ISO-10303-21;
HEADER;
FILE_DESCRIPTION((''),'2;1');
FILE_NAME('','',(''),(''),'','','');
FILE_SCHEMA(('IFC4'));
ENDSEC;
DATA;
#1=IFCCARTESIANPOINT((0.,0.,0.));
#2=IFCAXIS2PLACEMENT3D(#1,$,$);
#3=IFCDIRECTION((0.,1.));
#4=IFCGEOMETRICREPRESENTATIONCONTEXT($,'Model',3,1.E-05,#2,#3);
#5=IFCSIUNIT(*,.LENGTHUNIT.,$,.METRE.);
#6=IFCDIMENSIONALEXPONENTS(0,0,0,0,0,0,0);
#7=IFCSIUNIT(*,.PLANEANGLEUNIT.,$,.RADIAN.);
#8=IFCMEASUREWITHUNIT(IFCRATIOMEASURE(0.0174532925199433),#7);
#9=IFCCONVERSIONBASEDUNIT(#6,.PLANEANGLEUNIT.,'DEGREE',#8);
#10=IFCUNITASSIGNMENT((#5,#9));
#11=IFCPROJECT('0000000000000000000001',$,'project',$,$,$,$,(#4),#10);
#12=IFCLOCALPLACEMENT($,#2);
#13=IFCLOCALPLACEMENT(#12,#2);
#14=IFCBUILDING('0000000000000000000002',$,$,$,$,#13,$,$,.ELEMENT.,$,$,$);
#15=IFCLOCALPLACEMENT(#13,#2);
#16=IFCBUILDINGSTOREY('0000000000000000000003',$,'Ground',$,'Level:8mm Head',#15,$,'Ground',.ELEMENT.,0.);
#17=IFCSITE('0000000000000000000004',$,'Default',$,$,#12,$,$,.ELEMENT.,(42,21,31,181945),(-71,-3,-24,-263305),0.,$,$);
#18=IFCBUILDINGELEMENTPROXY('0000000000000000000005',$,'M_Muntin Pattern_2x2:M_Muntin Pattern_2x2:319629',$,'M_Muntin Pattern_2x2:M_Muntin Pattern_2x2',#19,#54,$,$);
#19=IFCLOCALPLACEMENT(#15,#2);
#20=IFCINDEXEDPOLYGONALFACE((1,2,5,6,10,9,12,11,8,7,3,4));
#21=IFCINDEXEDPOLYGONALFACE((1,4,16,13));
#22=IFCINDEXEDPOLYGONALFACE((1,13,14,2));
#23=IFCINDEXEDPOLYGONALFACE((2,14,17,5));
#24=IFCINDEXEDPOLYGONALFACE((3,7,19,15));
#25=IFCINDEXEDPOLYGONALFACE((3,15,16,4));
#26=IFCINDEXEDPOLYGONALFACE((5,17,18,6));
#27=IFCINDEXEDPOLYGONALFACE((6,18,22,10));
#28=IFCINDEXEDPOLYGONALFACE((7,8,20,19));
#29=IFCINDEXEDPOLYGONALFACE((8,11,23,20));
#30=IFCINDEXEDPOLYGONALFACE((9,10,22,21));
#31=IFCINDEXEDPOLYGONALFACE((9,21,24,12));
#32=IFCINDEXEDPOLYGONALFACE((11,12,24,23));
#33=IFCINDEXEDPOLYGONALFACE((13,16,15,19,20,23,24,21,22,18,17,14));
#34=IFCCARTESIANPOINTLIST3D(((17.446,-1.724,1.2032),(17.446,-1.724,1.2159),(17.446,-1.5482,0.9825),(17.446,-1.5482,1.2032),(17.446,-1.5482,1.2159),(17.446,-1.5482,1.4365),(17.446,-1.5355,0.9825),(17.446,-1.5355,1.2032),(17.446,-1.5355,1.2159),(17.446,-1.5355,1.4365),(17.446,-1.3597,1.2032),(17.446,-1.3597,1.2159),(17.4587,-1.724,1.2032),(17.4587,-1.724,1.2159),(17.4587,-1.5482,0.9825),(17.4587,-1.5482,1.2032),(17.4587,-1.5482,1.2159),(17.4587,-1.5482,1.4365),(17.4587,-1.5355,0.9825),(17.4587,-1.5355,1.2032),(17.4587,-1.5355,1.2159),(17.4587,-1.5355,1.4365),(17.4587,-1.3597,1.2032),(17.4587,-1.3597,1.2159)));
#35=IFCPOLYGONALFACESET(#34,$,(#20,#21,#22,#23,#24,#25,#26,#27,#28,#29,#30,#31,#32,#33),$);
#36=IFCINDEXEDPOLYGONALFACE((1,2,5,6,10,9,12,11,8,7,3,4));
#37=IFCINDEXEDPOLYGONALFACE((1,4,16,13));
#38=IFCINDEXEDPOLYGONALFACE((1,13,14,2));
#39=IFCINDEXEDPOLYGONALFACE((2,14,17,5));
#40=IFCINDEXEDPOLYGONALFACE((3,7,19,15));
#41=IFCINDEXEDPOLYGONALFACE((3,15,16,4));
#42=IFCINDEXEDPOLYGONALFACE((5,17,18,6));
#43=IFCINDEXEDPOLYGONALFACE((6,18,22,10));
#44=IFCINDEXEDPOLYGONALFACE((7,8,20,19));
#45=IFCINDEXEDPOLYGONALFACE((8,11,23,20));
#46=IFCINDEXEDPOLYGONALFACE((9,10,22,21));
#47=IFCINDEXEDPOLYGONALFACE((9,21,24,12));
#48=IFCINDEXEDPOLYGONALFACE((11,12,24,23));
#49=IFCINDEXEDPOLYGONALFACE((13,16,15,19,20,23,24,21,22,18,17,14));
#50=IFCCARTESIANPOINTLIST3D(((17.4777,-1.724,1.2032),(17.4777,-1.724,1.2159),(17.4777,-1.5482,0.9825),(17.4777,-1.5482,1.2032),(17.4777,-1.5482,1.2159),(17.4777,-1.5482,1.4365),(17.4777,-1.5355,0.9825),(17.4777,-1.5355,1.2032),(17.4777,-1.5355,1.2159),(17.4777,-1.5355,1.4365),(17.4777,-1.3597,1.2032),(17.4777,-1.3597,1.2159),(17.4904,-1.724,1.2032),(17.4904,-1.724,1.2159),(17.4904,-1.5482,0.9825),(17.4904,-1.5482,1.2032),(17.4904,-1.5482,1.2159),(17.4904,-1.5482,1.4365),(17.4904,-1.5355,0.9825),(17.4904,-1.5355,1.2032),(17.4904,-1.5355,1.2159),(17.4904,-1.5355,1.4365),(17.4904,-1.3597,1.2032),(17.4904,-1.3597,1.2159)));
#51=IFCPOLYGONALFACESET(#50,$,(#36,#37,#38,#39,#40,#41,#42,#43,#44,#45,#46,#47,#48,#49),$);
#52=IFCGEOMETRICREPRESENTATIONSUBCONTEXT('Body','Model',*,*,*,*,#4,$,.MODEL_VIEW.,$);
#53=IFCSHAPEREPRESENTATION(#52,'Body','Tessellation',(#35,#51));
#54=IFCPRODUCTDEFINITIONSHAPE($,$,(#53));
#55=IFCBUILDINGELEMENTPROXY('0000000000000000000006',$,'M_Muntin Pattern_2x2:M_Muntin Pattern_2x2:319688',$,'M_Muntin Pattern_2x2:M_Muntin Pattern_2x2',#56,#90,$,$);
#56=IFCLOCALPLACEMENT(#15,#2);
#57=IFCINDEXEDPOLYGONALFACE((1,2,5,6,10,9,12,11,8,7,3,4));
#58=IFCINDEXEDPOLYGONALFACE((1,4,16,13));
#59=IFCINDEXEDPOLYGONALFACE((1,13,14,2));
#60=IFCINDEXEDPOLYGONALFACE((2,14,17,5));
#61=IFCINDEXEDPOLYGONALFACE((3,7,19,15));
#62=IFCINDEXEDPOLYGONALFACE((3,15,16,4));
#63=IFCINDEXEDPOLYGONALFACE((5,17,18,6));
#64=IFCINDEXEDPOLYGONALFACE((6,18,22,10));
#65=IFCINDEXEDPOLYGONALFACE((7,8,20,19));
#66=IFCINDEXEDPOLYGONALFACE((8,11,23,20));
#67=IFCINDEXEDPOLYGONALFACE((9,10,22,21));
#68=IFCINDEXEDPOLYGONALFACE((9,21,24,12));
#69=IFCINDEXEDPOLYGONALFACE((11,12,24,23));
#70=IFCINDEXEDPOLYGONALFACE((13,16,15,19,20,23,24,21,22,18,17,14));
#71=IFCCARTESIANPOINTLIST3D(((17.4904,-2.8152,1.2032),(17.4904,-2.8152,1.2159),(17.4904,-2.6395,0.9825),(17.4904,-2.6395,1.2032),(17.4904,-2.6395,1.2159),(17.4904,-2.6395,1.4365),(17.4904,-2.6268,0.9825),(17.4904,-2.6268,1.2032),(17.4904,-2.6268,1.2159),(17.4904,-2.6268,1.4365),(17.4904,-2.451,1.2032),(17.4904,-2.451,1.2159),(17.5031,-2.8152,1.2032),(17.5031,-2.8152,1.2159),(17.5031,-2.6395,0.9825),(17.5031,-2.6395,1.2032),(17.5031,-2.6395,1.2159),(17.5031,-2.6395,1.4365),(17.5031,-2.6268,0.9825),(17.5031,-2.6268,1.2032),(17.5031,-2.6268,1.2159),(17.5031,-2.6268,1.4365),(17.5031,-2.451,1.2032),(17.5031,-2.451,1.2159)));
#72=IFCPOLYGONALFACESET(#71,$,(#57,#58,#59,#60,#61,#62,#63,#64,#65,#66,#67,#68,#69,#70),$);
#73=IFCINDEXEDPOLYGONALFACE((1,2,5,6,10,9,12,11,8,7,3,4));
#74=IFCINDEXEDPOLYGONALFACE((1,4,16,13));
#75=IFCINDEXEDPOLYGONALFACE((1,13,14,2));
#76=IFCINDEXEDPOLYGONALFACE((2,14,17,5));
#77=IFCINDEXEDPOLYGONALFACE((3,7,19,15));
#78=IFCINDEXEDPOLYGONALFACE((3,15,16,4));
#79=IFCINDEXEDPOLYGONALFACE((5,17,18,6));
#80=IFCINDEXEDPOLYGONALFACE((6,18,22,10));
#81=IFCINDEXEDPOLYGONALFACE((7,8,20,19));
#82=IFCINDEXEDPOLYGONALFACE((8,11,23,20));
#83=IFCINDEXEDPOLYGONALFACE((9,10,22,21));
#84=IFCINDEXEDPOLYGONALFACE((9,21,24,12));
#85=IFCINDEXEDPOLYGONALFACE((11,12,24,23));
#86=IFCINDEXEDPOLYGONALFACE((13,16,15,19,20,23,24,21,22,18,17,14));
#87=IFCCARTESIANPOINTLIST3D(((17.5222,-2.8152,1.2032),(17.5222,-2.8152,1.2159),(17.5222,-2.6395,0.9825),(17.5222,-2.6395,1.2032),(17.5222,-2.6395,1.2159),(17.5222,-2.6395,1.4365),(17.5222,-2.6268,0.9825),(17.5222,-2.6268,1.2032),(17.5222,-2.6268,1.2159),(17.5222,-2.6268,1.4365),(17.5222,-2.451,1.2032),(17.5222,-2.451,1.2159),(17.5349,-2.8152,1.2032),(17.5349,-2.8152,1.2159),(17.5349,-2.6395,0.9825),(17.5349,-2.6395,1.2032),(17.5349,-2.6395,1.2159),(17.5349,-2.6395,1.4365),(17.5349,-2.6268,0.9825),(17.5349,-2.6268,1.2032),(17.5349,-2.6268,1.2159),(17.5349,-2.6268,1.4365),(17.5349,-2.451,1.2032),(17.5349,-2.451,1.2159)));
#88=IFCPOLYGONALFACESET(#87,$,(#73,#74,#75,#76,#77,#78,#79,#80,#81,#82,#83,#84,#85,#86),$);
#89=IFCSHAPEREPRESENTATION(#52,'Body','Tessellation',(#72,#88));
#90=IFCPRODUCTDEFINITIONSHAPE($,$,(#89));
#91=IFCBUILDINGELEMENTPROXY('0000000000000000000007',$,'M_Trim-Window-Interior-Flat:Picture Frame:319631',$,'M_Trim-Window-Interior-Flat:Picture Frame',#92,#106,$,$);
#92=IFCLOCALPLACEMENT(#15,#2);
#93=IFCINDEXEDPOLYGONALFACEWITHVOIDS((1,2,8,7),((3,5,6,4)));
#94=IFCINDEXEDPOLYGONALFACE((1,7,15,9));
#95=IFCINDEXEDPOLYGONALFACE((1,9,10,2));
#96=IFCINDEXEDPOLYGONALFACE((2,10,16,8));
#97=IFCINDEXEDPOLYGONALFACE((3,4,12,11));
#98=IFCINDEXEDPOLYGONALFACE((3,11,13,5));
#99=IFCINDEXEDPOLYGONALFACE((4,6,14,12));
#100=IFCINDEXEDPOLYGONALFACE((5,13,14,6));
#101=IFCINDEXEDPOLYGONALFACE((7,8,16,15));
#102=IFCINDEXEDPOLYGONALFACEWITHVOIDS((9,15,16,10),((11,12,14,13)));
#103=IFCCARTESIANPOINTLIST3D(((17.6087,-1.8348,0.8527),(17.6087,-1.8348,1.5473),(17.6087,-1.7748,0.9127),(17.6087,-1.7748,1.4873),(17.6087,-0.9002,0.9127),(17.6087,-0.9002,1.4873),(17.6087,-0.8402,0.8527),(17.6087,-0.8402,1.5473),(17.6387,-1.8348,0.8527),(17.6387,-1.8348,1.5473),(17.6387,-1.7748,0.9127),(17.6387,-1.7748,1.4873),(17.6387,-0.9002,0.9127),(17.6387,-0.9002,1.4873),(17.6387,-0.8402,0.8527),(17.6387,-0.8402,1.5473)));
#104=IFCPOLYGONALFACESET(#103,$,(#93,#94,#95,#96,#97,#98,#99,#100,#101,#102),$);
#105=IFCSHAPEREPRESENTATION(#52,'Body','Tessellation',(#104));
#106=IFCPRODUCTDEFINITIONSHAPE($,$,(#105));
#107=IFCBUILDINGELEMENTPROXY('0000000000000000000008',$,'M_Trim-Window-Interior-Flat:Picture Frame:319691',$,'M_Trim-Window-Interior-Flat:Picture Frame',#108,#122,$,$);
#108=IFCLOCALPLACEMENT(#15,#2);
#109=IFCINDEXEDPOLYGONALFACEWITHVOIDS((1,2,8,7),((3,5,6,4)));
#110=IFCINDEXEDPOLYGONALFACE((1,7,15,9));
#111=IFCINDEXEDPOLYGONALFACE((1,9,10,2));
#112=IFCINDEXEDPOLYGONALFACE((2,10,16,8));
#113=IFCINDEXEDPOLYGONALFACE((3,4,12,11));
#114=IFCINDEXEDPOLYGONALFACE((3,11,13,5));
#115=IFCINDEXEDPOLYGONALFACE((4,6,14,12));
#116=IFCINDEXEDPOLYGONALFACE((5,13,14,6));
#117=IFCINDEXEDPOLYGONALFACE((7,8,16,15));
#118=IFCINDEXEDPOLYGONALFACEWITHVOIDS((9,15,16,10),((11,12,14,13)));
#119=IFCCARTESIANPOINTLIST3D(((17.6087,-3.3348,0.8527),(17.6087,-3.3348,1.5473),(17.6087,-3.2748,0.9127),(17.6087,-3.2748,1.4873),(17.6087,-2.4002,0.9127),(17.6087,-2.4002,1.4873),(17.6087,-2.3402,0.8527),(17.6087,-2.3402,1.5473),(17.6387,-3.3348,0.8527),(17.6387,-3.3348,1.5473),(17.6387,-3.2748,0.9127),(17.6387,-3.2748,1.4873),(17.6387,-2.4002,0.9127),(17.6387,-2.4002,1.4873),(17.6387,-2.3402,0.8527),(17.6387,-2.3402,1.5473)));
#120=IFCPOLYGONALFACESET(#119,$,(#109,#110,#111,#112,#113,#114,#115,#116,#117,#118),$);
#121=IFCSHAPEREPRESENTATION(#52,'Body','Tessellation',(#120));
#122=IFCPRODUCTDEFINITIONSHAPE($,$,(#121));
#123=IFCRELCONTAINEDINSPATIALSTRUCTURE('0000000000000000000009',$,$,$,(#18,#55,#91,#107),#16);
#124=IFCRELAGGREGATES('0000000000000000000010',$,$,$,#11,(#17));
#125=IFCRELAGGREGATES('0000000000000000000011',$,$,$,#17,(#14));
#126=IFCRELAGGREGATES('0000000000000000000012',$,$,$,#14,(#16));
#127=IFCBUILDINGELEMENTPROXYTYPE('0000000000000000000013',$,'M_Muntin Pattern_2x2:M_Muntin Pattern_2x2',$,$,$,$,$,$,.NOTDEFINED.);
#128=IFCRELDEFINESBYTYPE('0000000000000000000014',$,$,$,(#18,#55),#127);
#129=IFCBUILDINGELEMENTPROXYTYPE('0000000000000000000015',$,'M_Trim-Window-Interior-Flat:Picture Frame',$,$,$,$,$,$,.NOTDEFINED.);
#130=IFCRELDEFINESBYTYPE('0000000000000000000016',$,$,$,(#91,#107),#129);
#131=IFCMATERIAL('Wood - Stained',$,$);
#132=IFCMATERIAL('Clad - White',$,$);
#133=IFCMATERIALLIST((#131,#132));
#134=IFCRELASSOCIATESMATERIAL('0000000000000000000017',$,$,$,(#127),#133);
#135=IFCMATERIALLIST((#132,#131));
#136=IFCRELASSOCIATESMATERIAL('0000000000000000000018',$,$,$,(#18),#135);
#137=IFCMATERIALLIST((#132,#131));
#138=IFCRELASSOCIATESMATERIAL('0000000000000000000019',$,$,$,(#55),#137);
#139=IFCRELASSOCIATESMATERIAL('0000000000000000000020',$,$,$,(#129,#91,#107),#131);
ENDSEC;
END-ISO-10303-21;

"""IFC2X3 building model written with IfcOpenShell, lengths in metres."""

from ifc_helpers import new_model, entity, si_unit, converted_unit, direction, frame, origin, place, context, subcontext, project, spatial, polyline, outline, extrude, source, transform, mapped, material, material_list, type_object, type_shapes, element, save


model = new_model("IFC2X3")

# Units and contexts
model_context = context("Model", 3, precision=1e-05, world=origin(), true_north=direction((0.0, 1.0)))
body_context = subcontext(model_context, "Body", "Model", "MODEL_VIEW")
ifc_project = project(units=[si_unit("LENGTHUNIT", "METRE"), converted_unit("PLANEANGLEUNIT", "DEGREE", entity("IfcRatioMeasure", 0.0174532925199433), si_unit("PLANEANGLEUNIT", "RADIAN"), dimensions=[0, 0, 0, 0, 0, 0, 0])], contexts=[model_context])

# Site, building, storey
site_placement = place(None, origin())
site = spatial("IfcSite", under=ifc_project, at=site_placement, Name="Default", CompositionType="ELEMENT", RefLatitude=(42, 21, 31, 181945), RefLongitude=(-71, -3, -24, -263305), RefElevation=0.0)
building_placement = place(site_placement, origin())
building = spatial("IfcBuilding", under=site, at=building_placement, CompositionType="ELEMENT")
storey_placement = place(building_placement, origin())
storey = spatial("IfcBuildingStorey", under=building, at=storey_placement, Name="Ground", ObjectType="Level:8mm Head", LongName="Ground", CompositionType="ELEMENT", Elevation=0.0)

# Building element proxies
ifc_material_1 = material(Name="Clad - White")
ifc_material_2 = material(Name="Wood - Stained")
ifc_material_list_1 = material_list([ifc_material_2, ifc_material_1])
building_element_proxy_type_1 = type_object("IfcBuildingElementProxyType", Name="M_Muntin Pattern_2x2:M_Muntin Pattern_2x2", PredefinedType="NOTDEFINED", material=ifc_material_list_1)
shared_shape_1 = source(origin(), body_context, "Body", "SweptSolid", [
    extrude(outline(polyline([(0.0064, -0.0064), (0.227, -0.0064), (0.227, 0.0063), (0.0064, 0.0063), (0.0064, 0.1821), (-0.0063, 0.1821), (-0.0063, 0.0063), (-0.227, 0.0063), (-0.227, -0.0064), (-0.0063, -0.0064), (-0.0063, -0.1821), (0.0064, -0.1821), (0.0064, -0.0064)])), frame((0.0, 0.0095, 0.227), z_axis=(0.0, 1.0, 0.0), x_axis=(0.0, 0.0, 1.0)), (0.0, 0.0, 1.0), 0.0127),
    extrude(outline(polyline([(0.0064, -0.0064), (0.227, -0.0064), (0.227, 0.0063), (0.0064, 0.0063), (0.0064, 0.1821), (-0.0063, 0.1821), (-0.0063, 0.0063), (-0.227, 0.0063), (-0.227, -0.0064), (-0.0063, -0.0064), (-0.0063, -0.1821), (0.0064, -0.1821), (0.0064, -0.0064)])), frame((0.0, -0.0222, 0.227), z_axis=(0.0, 1.0, 0.0), x_axis=(0.0, 0.0, 1.0)), (0.0, 0.0, 1.0), 0.0127),
])
type_shapes(building_element_proxy_type_1, [shared_shape_1])
ifc_material_list_2 = material_list([ifc_material_1, ifc_material_2])
proxy_1_placement = place(storey_placement, frame((17.4682, -1.5418, 0.9825), z_axis=(0.0, 0.0, 1.0), x_axis=(0.0, 1.0, 0.0)))
element("IfcBuildingElementProxy", 1, at=proxy_1_placement, inside=storey, type_object=building_element_proxy_type_1, material=ifc_material_list_2, Name="M_Muntin Pattern_2x2:M_Muntin Pattern_2x2:319629", ObjectType="M_Muntin Pattern_2x2:M_Muntin Pattern_2x2", context=body_context, shape_type="MappedRepresentation", body=[
    mapped(shared_shape_1, transform((0.0, 0.0, 0.0), scale=1.0)),
])
ifc_material_list_3 = material_list([ifc_material_1, ifc_material_2])
proxy_2_placement = place(storey_placement, frame((17.5126, -2.6331, 0.9825), z_axis=(0.0, 0.0, 1.0), x_axis=(0.0, 1.0, 0.0)))
element("IfcBuildingElementProxy", 2, at=proxy_2_placement, inside=storey, type_object=building_element_proxy_type_1, material=ifc_material_list_3, Name="M_Muntin Pattern_2x2:M_Muntin Pattern_2x2:319688", ObjectType="M_Muntin Pattern_2x2:M_Muntin Pattern_2x2", context=body_context, shape_type="MappedRepresentation", body=[
    mapped(shared_shape_1, transform((0.0, 0.0, 0.0), scale=1.0)),
])
building_element_proxy_type_2 = type_object("IfcBuildingElementProxyType", Name="M_Trim-Window-Interior-Flat:Picture Frame", PredefinedType="NOTDEFINED", material=ifc_material_2)
shared_shape_2 = source(origin(), body_context, "Body", "SweptSolid", [
    extrude(outline(polyline([(-0.4973, -0.3473), (0.4973, -0.3473), (0.4973, 0.3473), (-0.4973, 0.3473), (-0.4973, -0.3473)]), holes=[polyline([(-0.4373, -0.2873), (-0.4373, 0.2873), (0.4373, 0.2873), (0.4373, -0.2873), (-0.4373, -0.2873)])]), frame((0.0, -0.3, 0.0), z_axis=(0.0, 0.0, 1.0), x_axis=(-1.0, 0.0, 0.0)), (0.0, 0.0, 1.0), 0.03),
])
type_shapes(building_element_proxy_type_2, [shared_shape_2])
for number, where, z_axis, x_axis, name in (
    (3, (17.6087, -1.3375, 1.5), (1.0, 0.0, 0.0), (0.0, 1.0, 0.0), "M_Trim-Window-Interior-Flat:Picture Frame:319631"),
    (4, (17.6087, -2.8375, 1.5), (1.0, 0.0, 0.0), (0.0, 1.0, 0.0), "M_Trim-Window-Interior-Flat:Picture Frame:319691"),
):
    element("IfcBuildingElementProxy", number, at=place(storey_placement, frame(where, z_axis=z_axis, x_axis=x_axis)), inside=storey, type_object=building_element_proxy_type_2, material=ifc_material_2, Name=name, ObjectType="M_Trim-Window-Interior-Flat:Picture Frame", context=body_context, shape_type="MappedRepresentation", body=[
        mapped(shared_shape_2, transform((0.0, 0.0, 0.0), scale=1.0)),
    ])

save(model, "model.ifc")
